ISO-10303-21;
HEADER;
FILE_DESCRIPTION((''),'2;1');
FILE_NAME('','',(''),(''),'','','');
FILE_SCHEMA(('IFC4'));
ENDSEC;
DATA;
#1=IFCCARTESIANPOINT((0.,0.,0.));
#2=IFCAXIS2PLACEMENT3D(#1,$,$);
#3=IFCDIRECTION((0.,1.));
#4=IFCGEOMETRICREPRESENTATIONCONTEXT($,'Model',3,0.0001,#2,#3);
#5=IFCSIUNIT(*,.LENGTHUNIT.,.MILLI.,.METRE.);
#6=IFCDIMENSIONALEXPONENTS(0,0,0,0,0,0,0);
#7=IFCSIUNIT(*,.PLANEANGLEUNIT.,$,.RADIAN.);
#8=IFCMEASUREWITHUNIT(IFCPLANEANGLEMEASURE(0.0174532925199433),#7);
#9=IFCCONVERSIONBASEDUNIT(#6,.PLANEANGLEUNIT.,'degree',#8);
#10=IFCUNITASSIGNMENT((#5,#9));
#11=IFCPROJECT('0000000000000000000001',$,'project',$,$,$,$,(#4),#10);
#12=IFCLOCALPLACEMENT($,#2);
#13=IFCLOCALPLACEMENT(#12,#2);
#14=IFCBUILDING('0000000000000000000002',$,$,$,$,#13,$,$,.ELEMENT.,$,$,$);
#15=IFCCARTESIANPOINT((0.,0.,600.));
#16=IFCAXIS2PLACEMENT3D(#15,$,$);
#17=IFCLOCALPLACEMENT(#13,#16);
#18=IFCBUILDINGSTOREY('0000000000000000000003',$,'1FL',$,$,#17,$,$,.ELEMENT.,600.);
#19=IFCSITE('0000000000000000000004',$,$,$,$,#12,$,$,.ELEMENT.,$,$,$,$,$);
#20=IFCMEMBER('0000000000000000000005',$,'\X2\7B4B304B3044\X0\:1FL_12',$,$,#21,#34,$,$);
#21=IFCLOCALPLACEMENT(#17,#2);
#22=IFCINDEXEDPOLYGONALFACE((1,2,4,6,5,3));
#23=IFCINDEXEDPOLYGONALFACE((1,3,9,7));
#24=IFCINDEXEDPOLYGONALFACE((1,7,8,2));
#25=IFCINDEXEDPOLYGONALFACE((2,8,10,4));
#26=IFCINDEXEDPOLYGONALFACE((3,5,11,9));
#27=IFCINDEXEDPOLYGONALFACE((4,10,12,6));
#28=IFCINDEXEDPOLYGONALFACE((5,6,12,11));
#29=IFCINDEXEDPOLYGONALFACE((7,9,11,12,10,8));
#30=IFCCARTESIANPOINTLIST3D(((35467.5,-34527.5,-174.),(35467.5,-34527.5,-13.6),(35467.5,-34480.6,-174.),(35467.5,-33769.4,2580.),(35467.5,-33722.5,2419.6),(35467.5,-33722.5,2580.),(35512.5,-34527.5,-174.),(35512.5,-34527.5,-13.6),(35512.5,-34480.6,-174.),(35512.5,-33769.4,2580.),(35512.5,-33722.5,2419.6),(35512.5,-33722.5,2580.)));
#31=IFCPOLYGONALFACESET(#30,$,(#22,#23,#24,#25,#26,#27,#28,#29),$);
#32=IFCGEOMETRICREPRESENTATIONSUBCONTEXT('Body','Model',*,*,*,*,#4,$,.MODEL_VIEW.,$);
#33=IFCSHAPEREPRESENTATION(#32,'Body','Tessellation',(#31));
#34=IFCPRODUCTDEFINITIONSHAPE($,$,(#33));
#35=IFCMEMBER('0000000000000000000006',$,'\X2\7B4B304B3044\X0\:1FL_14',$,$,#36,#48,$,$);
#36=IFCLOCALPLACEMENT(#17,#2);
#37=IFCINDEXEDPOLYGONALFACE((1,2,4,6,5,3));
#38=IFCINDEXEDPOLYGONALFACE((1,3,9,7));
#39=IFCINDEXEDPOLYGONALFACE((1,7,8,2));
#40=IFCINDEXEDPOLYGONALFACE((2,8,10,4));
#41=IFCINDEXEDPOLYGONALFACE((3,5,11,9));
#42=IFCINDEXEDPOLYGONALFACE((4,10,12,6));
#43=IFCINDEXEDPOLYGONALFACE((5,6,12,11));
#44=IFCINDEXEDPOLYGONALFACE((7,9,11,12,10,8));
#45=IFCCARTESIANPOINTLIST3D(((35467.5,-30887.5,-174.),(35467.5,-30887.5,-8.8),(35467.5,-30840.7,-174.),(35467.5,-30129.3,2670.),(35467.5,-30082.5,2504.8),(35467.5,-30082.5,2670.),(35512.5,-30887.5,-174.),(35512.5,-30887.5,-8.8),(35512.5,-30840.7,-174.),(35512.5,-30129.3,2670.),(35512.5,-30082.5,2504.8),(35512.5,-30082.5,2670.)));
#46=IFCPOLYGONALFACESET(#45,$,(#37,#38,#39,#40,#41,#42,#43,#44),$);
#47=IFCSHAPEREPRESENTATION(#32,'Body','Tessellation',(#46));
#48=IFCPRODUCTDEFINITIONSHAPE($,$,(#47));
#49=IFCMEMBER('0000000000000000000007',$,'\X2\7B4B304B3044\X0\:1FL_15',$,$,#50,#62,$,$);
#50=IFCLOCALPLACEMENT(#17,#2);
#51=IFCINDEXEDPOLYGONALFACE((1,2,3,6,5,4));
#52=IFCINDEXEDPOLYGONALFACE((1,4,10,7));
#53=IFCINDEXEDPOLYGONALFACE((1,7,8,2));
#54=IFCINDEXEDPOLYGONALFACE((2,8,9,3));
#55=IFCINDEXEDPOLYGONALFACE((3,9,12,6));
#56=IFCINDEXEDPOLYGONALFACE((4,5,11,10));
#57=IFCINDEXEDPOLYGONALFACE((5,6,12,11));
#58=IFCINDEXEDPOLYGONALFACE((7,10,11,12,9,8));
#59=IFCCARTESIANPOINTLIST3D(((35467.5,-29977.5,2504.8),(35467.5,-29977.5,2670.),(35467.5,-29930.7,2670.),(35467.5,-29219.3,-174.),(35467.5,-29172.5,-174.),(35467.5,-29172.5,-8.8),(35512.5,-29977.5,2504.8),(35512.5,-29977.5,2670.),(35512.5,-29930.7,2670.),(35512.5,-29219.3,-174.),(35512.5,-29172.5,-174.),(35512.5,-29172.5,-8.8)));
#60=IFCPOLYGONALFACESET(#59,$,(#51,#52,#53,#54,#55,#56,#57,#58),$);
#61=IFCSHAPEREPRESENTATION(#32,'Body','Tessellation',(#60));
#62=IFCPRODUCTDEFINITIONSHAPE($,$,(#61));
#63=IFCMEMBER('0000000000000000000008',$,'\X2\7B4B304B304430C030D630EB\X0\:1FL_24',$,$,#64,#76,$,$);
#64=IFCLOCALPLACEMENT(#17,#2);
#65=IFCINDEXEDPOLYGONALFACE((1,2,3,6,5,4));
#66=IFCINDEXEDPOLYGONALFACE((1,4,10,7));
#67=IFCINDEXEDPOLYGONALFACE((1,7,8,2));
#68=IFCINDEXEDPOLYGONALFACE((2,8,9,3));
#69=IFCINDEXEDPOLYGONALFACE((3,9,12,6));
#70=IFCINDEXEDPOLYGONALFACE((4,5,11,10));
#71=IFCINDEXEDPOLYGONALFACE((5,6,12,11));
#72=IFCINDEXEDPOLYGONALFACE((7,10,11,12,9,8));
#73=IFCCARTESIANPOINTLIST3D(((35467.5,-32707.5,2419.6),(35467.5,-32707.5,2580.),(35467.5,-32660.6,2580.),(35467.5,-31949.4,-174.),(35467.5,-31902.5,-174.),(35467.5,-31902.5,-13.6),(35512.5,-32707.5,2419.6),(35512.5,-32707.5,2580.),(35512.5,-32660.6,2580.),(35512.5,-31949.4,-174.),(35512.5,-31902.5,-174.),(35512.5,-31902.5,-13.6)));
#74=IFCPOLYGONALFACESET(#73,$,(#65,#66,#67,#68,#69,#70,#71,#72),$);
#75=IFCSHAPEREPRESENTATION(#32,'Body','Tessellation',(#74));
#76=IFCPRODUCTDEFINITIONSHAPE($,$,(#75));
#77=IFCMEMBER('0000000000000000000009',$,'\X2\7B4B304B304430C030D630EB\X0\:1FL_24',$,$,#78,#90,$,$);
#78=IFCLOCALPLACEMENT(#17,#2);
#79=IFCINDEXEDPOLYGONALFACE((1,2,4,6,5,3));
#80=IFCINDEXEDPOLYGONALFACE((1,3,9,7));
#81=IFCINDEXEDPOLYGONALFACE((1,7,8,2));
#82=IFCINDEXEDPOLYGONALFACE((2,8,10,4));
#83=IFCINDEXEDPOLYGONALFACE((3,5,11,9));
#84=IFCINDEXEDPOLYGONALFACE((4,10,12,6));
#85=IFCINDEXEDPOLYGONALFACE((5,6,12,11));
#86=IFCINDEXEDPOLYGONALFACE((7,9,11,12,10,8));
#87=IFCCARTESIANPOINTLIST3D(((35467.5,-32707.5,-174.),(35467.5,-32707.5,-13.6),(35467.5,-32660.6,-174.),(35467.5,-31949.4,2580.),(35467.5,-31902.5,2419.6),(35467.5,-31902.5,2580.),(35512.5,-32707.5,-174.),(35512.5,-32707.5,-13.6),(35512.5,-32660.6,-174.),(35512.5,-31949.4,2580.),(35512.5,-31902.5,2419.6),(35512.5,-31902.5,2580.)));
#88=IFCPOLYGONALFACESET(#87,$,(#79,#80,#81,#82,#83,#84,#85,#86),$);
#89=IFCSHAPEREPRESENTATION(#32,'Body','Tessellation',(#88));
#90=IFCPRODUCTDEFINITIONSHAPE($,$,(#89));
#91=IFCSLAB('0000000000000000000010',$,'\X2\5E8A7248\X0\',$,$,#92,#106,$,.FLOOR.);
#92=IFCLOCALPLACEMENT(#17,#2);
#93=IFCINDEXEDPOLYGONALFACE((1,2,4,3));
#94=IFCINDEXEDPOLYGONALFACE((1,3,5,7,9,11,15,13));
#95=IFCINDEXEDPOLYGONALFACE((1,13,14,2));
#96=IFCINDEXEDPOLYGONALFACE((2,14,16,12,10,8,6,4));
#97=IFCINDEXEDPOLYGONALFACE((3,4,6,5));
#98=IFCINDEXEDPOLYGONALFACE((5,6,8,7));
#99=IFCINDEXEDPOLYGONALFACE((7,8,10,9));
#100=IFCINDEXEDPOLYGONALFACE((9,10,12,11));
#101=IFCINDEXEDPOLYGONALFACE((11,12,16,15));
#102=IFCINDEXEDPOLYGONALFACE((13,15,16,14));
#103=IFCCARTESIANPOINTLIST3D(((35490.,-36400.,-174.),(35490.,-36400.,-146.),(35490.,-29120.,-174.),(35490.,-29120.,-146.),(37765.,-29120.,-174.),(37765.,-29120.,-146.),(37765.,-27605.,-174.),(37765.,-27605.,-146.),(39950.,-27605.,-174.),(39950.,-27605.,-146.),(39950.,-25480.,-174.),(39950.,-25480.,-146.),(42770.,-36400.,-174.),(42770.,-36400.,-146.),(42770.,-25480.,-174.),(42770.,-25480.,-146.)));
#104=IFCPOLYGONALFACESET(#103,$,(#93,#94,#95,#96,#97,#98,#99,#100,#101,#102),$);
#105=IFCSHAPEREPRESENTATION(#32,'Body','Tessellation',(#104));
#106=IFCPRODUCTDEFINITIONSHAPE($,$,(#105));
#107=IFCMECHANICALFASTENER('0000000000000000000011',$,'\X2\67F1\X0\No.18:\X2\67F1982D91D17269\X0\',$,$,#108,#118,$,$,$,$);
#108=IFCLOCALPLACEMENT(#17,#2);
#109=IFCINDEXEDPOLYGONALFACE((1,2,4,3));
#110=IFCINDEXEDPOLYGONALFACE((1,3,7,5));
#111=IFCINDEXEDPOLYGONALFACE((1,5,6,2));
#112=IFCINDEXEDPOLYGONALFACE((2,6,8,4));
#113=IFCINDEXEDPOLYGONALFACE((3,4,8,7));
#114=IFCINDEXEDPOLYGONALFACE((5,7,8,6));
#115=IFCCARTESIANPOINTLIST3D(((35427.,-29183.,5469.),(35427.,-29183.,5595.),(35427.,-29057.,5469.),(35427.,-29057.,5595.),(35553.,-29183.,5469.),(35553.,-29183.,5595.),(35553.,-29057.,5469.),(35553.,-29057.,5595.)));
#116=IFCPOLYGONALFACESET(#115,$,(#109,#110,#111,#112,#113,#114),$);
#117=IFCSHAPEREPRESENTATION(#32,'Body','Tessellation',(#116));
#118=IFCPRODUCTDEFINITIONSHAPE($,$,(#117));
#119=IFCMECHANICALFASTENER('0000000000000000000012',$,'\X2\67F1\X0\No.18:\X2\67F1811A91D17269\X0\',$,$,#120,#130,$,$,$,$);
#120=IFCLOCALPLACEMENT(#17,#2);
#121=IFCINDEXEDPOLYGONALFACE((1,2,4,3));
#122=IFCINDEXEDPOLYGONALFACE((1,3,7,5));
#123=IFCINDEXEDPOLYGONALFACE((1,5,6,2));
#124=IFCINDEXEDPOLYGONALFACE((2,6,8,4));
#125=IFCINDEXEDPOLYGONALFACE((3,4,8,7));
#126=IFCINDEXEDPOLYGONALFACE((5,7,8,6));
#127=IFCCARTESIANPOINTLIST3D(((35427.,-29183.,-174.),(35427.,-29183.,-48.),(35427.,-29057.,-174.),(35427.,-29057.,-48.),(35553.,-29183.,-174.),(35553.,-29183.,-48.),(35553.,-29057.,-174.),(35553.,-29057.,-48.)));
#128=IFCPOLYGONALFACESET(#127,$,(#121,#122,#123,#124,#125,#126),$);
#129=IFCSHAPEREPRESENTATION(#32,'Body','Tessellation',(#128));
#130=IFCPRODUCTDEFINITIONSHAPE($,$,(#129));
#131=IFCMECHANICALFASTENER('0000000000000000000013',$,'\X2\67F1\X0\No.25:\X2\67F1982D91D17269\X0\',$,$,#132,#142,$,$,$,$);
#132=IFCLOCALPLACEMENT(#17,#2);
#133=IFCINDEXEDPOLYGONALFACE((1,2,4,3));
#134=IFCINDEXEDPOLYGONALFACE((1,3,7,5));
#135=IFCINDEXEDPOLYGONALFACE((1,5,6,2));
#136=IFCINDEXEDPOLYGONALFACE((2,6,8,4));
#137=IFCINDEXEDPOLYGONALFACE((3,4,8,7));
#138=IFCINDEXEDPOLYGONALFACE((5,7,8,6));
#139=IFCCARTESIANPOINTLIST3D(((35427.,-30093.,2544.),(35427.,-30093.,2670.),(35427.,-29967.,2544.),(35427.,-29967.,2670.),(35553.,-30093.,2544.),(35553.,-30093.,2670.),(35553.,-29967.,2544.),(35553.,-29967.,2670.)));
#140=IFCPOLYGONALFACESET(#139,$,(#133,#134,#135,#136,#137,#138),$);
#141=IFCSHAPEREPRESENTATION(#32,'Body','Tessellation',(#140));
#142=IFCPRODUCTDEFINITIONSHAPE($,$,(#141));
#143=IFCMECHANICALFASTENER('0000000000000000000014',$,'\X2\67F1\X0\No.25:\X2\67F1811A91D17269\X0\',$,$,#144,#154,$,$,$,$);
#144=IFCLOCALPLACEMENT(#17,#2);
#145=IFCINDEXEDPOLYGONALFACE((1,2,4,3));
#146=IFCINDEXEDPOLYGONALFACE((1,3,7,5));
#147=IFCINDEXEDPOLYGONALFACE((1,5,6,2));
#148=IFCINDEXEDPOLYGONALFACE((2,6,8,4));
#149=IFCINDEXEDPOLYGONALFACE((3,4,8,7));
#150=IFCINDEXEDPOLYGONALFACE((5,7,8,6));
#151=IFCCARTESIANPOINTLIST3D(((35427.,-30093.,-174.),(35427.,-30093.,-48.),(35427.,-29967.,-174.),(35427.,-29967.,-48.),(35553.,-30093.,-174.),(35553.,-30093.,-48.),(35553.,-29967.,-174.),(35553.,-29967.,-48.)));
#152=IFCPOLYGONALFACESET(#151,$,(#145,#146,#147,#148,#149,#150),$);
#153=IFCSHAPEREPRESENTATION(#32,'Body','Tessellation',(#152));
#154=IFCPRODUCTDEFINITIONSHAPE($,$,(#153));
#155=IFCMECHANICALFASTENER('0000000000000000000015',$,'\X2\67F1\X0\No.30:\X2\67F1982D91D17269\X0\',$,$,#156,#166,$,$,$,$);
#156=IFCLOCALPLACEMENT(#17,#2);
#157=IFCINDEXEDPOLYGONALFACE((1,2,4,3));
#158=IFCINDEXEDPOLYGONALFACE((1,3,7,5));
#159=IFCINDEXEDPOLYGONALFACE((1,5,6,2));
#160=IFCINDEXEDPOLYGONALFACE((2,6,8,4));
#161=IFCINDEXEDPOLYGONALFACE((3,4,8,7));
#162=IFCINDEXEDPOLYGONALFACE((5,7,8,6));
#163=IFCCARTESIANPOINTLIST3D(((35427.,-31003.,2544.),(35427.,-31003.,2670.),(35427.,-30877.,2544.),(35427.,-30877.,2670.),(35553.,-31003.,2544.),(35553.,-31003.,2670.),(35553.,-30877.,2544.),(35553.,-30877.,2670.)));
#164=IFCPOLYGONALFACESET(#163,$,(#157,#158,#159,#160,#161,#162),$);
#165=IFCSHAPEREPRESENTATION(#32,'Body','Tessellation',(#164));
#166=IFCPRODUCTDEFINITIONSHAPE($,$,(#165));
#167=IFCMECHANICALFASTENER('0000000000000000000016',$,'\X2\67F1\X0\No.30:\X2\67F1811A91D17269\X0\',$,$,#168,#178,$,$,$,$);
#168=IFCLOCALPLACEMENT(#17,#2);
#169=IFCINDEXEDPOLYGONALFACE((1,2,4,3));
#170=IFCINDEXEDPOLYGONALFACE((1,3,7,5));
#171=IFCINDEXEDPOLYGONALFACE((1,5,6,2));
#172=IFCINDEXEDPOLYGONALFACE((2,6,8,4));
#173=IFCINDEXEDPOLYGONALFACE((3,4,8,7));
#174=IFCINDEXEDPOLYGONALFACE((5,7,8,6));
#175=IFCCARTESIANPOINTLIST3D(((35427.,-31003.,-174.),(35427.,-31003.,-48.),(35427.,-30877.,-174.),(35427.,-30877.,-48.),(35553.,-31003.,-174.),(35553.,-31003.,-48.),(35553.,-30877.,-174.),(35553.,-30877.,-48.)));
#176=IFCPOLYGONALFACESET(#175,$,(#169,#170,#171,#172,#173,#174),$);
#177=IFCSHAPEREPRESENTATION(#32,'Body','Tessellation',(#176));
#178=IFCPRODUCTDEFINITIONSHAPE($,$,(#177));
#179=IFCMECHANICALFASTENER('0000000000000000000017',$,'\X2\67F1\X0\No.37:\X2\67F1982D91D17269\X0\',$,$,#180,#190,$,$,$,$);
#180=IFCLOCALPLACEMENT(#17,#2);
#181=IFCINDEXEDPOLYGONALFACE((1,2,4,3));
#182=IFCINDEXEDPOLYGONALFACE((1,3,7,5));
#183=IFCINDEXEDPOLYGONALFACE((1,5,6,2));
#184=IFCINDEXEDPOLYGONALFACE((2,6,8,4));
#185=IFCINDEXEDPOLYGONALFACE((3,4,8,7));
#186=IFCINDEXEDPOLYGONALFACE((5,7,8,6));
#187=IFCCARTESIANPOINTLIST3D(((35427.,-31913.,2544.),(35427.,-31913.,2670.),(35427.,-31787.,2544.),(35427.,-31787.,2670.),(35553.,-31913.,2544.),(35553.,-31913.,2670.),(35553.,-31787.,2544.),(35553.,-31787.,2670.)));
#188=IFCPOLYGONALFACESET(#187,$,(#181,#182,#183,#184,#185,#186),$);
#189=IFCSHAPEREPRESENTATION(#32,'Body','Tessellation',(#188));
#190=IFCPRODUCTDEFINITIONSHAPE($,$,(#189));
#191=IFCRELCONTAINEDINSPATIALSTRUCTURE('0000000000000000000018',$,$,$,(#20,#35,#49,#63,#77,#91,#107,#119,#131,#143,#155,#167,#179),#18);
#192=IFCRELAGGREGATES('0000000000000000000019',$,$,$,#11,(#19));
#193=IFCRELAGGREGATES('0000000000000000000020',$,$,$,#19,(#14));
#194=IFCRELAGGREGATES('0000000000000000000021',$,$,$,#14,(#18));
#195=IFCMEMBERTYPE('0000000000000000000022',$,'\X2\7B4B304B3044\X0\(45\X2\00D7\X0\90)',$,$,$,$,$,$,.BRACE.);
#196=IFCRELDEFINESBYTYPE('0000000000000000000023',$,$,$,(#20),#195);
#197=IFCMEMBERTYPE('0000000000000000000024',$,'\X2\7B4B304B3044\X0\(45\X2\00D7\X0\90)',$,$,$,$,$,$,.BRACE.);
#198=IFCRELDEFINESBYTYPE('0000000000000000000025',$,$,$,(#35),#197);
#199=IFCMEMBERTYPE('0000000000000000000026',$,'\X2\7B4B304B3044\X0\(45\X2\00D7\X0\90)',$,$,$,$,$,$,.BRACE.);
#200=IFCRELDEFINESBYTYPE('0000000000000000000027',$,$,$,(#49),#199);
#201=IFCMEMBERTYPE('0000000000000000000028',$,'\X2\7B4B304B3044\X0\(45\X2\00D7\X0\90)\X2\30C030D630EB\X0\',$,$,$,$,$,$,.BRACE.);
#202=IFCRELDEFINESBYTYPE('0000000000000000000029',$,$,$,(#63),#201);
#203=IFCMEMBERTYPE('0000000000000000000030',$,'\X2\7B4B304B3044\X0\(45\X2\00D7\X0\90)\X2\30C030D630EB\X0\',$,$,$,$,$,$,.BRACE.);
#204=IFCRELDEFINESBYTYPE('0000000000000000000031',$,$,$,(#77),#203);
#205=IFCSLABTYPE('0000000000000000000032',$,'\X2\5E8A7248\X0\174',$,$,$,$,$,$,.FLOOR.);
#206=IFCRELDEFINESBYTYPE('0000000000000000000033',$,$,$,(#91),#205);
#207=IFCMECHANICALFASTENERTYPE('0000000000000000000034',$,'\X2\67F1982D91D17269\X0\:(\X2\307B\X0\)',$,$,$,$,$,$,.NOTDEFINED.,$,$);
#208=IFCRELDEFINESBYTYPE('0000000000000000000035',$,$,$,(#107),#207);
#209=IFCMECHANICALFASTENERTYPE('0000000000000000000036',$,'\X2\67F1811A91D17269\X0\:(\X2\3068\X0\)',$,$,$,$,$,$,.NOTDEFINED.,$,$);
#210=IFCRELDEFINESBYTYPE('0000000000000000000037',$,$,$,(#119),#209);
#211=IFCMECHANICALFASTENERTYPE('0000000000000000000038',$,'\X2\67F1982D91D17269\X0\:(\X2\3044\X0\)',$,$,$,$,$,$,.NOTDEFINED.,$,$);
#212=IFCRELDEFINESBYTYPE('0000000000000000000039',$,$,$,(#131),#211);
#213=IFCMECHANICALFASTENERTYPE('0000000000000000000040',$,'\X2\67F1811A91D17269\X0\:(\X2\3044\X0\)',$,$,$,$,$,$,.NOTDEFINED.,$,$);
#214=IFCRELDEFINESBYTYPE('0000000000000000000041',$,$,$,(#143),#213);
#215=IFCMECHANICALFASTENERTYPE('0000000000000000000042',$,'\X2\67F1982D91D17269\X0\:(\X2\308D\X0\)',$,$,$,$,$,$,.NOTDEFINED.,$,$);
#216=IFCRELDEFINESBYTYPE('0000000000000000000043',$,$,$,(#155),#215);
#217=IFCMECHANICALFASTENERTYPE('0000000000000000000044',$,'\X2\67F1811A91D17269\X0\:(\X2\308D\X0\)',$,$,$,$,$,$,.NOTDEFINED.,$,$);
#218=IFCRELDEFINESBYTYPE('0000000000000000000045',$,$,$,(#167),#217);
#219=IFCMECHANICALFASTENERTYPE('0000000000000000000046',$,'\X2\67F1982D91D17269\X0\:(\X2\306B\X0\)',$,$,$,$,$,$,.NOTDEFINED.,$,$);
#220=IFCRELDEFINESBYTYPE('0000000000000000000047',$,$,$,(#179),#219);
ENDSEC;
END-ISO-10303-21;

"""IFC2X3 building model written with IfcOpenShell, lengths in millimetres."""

from ifc_helpers import new_model, entity, si_unit, converted_unit, direction, frame, origin, origin_with_axes, origin_2d, place, context, subcontext, project, spatial, polyline, rectangle, outline, extrude, type_object, element, save


model = new_model("IFC2X3")

# Units and contexts
model_context = context("Model", 3, precision=0.0001, world=origin(), true_north=direction((0.0, 1.0)))
body_context = subcontext(model_context, "Body", "Model", "MODEL_VIEW")
ifc_project = project(units=[si_unit("LENGTHUNIT", "METRE", prefix="MILLI"), converted_unit("PLANEANGLEUNIT", "degree", entity("IfcPlaneAngleMeasure", 0.0174532925199433), si_unit("PLANEANGLEUNIT", "RADIAN"), dimensions=[0, 0, 0, 0, 0, 0, 0])], contexts=[model_context])

# Site, building, storey
site_placement = place(None, origin())
site = spatial("IfcSite", under=ifc_project, at=site_placement, CompositionType="ELEMENT")
building_placement = place(site_placement, origin())
building = spatial("IfcBuilding", under=site, at=building_placement, CompositionType="ELEMENT")
storey_placement = place(building_placement, frame((0.0, 0.0, 600.0)))
storey = spatial("IfcBuildingStorey", under=building, at=storey_placement, Name="1FL", CompositionType="ELEMENT", Elevation=600.0)

# Members
member_type_1 = type_object("IfcMemberType", Name="筋かい(45×90)", PredefinedType="BRACE")
member_1_placement = place(storey_placement, frame((35490.0, -34527.5, -174.0), z_axis=(0.0, 0.280562, 0.959836), x_axis=(0.0, -0.959836, 0.280562)))
element("IfcMember", 1, at=member_1_placement, inside=storey, type_object=member_type_1, Name="筋かい:1FL_12", context=body_context, shape_type="SweptSolid", body=[
    extrude(outline(polyline([(0.0, 0.0), (13.2, -45.0), (2715.3, -45.0), (2869.2, 0.0), (2856.1, 45.0), (154.0, 45.0), (0.0, 0.0)])), frame((0.0, -22.5, 0.0), z_axis=(0.0, 1.0, 0.0), x_axis=(0.0, 0.0, 1.0)), (0.0, 0.0, 1.0), 45.0),
])
member_type_2 = type_object("IfcMemberType", Name="筋かい(45×90)", PredefinedType="BRACE")
member_2_placement = place(storey_placement, frame((35490.0, -30887.5, -174.0), z_axis=(0.0, 0.272352, 0.962198), x_axis=(0.0, -0.962198, 0.272352)))
element("IfcMember", 2, at=member_2_placement, inside=storey, type_object=member_type_2, Name="筋かい:1FL_14", context=body_context, shape_type="SweptSolid", body=[
    extrude(outline(polyline([(0.0, 0.0), (12.7, -45.0), (2796.8, -45.0), (2955.7, 0.0), (2943.0, 45.0), (159.0, 45.0), (0.0, 0.0)])), frame((0.0, -22.5, 0.0), z_axis=(0.0, 1.0, 0.0), x_axis=(0.0, 0.0, 1.0)), (0.0, 0.0, 1.0), 45.0),
])
member_type_3 = type_object("IfcMemberType", Name="筋かい(45×90)", PredefinedType="BRACE")
member_3_placement = place(storey_placement, frame((35490.0, -29172.5, -174.0), z_axis=(0.0, -0.272352, 0.962198), x_axis=(0.0, 0.962198, 0.272352)))
element("IfcMember", 3, at=member_3_placement, inside=storey, type_object=member_type_3, Name="筋かい:1FL_15", context=body_context, shape_type="SweptSolid", body=[
    extrude(outline(polyline([(0.0, 0.0), (12.7, -45.0), (2796.8, -45.0), (2955.7, 0.0), (2943.0, 45.0), (159.0, 45.0), (0.0, 0.0)])), frame((0.0, -22.5, 0.0), z_axis=(0.0, 1.0, 0.0), x_axis=(0.0, 0.0, 1.0)), (0.0, 0.0, 1.0), 45.0),
])
member_type_4 = type_object("IfcMemberType", Name="筋かい(45×90)ダブル", PredefinedType="BRACE")
member_4_placement = place(storey_placement, frame((35490.0, -31902.5, -174.0), z_axis=(0.0, -0.280562, 0.959836), x_axis=(0.0, 0.959836, 0.280562)))
element("IfcMember", 4, at=member_4_placement, inside=storey, type_object=member_type_4, Name="筋かいダブル:1FL_24", context=body_context, shape_type="SweptSolid", body=[
    extrude(outline(polyline([(0.0, 0.0), (13.2, -45.0), (2715.3, -45.0), (2869.2, 0.0), (2856.1, 45.0), (154.0, 45.0), (0.0, 0.0)])), frame((0.0, -22.5, 0.0), z_axis=(0.0, 1.0, 0.0), x_axis=(0.0, 0.0, 1.0)), (0.0, 0.0, 1.0), 45.0),
])
member_type_5 = type_object("IfcMemberType", Name="筋かい(45×90)ダブル", PredefinedType="BRACE")
member_5_placement = place(storey_placement, frame((35490.0, -32707.5, -174.0), z_axis=(0.0, 0.280562, 0.959836), x_axis=(0.0, -0.959836, 0.280562)))
element("IfcMember", 5, at=member_5_placement, inside=storey, type_object=member_type_5, Name="筋かいダブル:1FL_24", context=body_context, shape_type="SweptSolid", body=[
    extrude(outline(polyline([(0.0, 0.0), (13.2, -45.0), (2715.3, -45.0), (2869.2, 0.0), (2856.1, 45.0), (154.0, 45.0), (0.0, 0.0)])), frame((0.0, -22.5, 0.0), z_axis=(0.0, 1.0, 0.0), x_axis=(0.0, 0.0, 1.0)), (0.0, 0.0, 1.0), 45.0),
])

# Slab
slab_type = type_object("IfcSlabType", Name="床版174", PredefinedType="FLOOR")
slab_placement = place(storey_placement, frame((0.0, 0.0, -174.0), z_axis=(0.0, 0.0, 1.0), x_axis=(1.0, 0.0, 0.0)))
element("IfcSlab", 6, at=slab_placement, inside=storey, type_object=slab_type, Name="床版", PredefinedType="FLOOR", context=body_context, shape_type="SweptSolid", body=[
    extrude(outline(polyline([(39950.0, -27605.0, 0.0), (37765.0, -27605.0, 0.0), (37765.0, -29120.0, 0.0), (35490.0, -29120.0, 0.0), (35490.0, -36400.0, 0.0), (42770.0, -36400.0, 0.0), (42770.0, -25480.0, 0.0), (39950.0, -25480.0, 0.0), (39950.0, -27605.0, 0.0)])), origin_with_axes(), (0.0, 0.0, 1.0), 28.0),
])

# Mechanical fasteners
mechanical_fastener_type_1 = type_object("IfcMechanicalFastenerType", Name="柱頭金物:(ほ)")
mechanical_fastener_1_placement = place(storey_placement, frame((35490.0, -29120.0, 5469.0)))
element("IfcMechanicalFastener", 7, at=mechanical_fastener_1_placement, inside=storey, type_object=mechanical_fastener_type_1, Name="柱No.18:柱頭金物", context=body_context, shape_type="SweptSolid", body=[
    extrude(rectangle(XDim=126.0, YDim=126.0, at=origin_2d()), origin_with_axes(), (0.0, 0.0, 1.0), 126.0),
])
mechanical_fastener_type_2 = type_object("IfcMechanicalFastenerType", Name="柱脚金物:(と)")
mechanical_fastener_2_placement = place(storey_placement, frame((35490.0, -29120.0, -174.0)))
element("IfcMechanicalFastener", 8, at=mechanical_fastener_2_placement, inside=storey, type_object=mechanical_fastener_type_2, Name="柱No.18:柱脚金物", context=body_context, shape_type="SweptSolid", body=[
    extrude(rectangle(XDim=126.0, YDim=126.0, at=origin_2d()), origin_with_axes(), (0.0, 0.0, 1.0), 126.0),
])
mechanical_fastener_type_3 = type_object("IfcMechanicalFastenerType", Name="柱頭金物:(い)")
mechanical_fastener_3_placement = place(storey_placement, frame((35490.0, -30030.0, 2544.0)))
element("IfcMechanicalFastener", 9, at=mechanical_fastener_3_placement, inside=storey, type_object=mechanical_fastener_type_3, Name="柱No.25:柱頭金物", context=body_context, shape_type="SweptSolid", body=[
    extrude(rectangle(XDim=126.0, YDim=126.0, at=origin_2d()), origin_with_axes(), (0.0, 0.0, 1.0), 126.0),
])
mechanical_fastener_type_4 = type_object("IfcMechanicalFastenerType", Name="柱脚金物:(い)")
mechanical_fastener_4_placement = place(storey_placement, frame((35490.0, -30030.0, -174.0)))
element("IfcMechanicalFastener", 10, at=mechanical_fastener_4_placement, inside=storey, type_object=mechanical_fastener_type_4, Name="柱No.25:柱脚金物", context=body_context, shape_type="SweptSolid", body=[
    extrude(rectangle(XDim=126.0, YDim=126.0, at=origin_2d()), origin_with_axes(), (0.0, 0.0, 1.0), 126.0),
])
mechanical_fastener_type_5 = type_object("IfcMechanicalFastenerType", Name="柱頭金物:(ろ)")
mechanical_fastener_5_placement = place(storey_placement, frame((35490.0, -30940.0, 2544.0)))
element("IfcMechanicalFastener", 11, at=mechanical_fastener_5_placement, inside=storey, type_object=mechanical_fastener_type_5, Name="柱No.30:柱頭金物", context=body_context, shape_type="SweptSolid", body=[
    extrude(rectangle(XDim=126.0, YDim=126.0, at=origin_2d()), origin_with_axes(), (0.0, 0.0, 1.0), 126.0),
])
mechanical_fastener_type_6 = type_object("IfcMechanicalFastenerType", Name="柱脚金物:(ろ)")
mechanical_fastener_6_placement = place(storey_placement, frame((35490.0, -30940.0, -174.0)))
element("IfcMechanicalFastener", 12, at=mechanical_fastener_6_placement, inside=storey, type_object=mechanical_fastener_type_6, Name="柱No.30:柱脚金物", context=body_context, shape_type="SweptSolid", body=[
    extrude(rectangle(XDim=126.0, YDim=126.0, at=origin_2d()), origin_with_axes(), (0.0, 0.0, 1.0), 126.0),
])
mechanical_fastener_type_7 = type_object("IfcMechanicalFastenerType", Name="柱頭金物:(に)")
mechanical_fastener_7_placement = place(storey_placement, frame((35490.0, -31850.0, 2544.0)))
element("IfcMechanicalFastener", 13, at=mechanical_fastener_7_placement, inside=storey, type_object=mechanical_fastener_type_7, Name="柱No.37:柱頭金物", context=body_context, shape_type="SweptSolid", body=[
    extrude(rectangle(XDim=126.0, YDim=126.0, at=origin_2d()), origin_with_axes(), (0.0, 0.0, 1.0), 126.0),
])

save(model, "model.ifc")
